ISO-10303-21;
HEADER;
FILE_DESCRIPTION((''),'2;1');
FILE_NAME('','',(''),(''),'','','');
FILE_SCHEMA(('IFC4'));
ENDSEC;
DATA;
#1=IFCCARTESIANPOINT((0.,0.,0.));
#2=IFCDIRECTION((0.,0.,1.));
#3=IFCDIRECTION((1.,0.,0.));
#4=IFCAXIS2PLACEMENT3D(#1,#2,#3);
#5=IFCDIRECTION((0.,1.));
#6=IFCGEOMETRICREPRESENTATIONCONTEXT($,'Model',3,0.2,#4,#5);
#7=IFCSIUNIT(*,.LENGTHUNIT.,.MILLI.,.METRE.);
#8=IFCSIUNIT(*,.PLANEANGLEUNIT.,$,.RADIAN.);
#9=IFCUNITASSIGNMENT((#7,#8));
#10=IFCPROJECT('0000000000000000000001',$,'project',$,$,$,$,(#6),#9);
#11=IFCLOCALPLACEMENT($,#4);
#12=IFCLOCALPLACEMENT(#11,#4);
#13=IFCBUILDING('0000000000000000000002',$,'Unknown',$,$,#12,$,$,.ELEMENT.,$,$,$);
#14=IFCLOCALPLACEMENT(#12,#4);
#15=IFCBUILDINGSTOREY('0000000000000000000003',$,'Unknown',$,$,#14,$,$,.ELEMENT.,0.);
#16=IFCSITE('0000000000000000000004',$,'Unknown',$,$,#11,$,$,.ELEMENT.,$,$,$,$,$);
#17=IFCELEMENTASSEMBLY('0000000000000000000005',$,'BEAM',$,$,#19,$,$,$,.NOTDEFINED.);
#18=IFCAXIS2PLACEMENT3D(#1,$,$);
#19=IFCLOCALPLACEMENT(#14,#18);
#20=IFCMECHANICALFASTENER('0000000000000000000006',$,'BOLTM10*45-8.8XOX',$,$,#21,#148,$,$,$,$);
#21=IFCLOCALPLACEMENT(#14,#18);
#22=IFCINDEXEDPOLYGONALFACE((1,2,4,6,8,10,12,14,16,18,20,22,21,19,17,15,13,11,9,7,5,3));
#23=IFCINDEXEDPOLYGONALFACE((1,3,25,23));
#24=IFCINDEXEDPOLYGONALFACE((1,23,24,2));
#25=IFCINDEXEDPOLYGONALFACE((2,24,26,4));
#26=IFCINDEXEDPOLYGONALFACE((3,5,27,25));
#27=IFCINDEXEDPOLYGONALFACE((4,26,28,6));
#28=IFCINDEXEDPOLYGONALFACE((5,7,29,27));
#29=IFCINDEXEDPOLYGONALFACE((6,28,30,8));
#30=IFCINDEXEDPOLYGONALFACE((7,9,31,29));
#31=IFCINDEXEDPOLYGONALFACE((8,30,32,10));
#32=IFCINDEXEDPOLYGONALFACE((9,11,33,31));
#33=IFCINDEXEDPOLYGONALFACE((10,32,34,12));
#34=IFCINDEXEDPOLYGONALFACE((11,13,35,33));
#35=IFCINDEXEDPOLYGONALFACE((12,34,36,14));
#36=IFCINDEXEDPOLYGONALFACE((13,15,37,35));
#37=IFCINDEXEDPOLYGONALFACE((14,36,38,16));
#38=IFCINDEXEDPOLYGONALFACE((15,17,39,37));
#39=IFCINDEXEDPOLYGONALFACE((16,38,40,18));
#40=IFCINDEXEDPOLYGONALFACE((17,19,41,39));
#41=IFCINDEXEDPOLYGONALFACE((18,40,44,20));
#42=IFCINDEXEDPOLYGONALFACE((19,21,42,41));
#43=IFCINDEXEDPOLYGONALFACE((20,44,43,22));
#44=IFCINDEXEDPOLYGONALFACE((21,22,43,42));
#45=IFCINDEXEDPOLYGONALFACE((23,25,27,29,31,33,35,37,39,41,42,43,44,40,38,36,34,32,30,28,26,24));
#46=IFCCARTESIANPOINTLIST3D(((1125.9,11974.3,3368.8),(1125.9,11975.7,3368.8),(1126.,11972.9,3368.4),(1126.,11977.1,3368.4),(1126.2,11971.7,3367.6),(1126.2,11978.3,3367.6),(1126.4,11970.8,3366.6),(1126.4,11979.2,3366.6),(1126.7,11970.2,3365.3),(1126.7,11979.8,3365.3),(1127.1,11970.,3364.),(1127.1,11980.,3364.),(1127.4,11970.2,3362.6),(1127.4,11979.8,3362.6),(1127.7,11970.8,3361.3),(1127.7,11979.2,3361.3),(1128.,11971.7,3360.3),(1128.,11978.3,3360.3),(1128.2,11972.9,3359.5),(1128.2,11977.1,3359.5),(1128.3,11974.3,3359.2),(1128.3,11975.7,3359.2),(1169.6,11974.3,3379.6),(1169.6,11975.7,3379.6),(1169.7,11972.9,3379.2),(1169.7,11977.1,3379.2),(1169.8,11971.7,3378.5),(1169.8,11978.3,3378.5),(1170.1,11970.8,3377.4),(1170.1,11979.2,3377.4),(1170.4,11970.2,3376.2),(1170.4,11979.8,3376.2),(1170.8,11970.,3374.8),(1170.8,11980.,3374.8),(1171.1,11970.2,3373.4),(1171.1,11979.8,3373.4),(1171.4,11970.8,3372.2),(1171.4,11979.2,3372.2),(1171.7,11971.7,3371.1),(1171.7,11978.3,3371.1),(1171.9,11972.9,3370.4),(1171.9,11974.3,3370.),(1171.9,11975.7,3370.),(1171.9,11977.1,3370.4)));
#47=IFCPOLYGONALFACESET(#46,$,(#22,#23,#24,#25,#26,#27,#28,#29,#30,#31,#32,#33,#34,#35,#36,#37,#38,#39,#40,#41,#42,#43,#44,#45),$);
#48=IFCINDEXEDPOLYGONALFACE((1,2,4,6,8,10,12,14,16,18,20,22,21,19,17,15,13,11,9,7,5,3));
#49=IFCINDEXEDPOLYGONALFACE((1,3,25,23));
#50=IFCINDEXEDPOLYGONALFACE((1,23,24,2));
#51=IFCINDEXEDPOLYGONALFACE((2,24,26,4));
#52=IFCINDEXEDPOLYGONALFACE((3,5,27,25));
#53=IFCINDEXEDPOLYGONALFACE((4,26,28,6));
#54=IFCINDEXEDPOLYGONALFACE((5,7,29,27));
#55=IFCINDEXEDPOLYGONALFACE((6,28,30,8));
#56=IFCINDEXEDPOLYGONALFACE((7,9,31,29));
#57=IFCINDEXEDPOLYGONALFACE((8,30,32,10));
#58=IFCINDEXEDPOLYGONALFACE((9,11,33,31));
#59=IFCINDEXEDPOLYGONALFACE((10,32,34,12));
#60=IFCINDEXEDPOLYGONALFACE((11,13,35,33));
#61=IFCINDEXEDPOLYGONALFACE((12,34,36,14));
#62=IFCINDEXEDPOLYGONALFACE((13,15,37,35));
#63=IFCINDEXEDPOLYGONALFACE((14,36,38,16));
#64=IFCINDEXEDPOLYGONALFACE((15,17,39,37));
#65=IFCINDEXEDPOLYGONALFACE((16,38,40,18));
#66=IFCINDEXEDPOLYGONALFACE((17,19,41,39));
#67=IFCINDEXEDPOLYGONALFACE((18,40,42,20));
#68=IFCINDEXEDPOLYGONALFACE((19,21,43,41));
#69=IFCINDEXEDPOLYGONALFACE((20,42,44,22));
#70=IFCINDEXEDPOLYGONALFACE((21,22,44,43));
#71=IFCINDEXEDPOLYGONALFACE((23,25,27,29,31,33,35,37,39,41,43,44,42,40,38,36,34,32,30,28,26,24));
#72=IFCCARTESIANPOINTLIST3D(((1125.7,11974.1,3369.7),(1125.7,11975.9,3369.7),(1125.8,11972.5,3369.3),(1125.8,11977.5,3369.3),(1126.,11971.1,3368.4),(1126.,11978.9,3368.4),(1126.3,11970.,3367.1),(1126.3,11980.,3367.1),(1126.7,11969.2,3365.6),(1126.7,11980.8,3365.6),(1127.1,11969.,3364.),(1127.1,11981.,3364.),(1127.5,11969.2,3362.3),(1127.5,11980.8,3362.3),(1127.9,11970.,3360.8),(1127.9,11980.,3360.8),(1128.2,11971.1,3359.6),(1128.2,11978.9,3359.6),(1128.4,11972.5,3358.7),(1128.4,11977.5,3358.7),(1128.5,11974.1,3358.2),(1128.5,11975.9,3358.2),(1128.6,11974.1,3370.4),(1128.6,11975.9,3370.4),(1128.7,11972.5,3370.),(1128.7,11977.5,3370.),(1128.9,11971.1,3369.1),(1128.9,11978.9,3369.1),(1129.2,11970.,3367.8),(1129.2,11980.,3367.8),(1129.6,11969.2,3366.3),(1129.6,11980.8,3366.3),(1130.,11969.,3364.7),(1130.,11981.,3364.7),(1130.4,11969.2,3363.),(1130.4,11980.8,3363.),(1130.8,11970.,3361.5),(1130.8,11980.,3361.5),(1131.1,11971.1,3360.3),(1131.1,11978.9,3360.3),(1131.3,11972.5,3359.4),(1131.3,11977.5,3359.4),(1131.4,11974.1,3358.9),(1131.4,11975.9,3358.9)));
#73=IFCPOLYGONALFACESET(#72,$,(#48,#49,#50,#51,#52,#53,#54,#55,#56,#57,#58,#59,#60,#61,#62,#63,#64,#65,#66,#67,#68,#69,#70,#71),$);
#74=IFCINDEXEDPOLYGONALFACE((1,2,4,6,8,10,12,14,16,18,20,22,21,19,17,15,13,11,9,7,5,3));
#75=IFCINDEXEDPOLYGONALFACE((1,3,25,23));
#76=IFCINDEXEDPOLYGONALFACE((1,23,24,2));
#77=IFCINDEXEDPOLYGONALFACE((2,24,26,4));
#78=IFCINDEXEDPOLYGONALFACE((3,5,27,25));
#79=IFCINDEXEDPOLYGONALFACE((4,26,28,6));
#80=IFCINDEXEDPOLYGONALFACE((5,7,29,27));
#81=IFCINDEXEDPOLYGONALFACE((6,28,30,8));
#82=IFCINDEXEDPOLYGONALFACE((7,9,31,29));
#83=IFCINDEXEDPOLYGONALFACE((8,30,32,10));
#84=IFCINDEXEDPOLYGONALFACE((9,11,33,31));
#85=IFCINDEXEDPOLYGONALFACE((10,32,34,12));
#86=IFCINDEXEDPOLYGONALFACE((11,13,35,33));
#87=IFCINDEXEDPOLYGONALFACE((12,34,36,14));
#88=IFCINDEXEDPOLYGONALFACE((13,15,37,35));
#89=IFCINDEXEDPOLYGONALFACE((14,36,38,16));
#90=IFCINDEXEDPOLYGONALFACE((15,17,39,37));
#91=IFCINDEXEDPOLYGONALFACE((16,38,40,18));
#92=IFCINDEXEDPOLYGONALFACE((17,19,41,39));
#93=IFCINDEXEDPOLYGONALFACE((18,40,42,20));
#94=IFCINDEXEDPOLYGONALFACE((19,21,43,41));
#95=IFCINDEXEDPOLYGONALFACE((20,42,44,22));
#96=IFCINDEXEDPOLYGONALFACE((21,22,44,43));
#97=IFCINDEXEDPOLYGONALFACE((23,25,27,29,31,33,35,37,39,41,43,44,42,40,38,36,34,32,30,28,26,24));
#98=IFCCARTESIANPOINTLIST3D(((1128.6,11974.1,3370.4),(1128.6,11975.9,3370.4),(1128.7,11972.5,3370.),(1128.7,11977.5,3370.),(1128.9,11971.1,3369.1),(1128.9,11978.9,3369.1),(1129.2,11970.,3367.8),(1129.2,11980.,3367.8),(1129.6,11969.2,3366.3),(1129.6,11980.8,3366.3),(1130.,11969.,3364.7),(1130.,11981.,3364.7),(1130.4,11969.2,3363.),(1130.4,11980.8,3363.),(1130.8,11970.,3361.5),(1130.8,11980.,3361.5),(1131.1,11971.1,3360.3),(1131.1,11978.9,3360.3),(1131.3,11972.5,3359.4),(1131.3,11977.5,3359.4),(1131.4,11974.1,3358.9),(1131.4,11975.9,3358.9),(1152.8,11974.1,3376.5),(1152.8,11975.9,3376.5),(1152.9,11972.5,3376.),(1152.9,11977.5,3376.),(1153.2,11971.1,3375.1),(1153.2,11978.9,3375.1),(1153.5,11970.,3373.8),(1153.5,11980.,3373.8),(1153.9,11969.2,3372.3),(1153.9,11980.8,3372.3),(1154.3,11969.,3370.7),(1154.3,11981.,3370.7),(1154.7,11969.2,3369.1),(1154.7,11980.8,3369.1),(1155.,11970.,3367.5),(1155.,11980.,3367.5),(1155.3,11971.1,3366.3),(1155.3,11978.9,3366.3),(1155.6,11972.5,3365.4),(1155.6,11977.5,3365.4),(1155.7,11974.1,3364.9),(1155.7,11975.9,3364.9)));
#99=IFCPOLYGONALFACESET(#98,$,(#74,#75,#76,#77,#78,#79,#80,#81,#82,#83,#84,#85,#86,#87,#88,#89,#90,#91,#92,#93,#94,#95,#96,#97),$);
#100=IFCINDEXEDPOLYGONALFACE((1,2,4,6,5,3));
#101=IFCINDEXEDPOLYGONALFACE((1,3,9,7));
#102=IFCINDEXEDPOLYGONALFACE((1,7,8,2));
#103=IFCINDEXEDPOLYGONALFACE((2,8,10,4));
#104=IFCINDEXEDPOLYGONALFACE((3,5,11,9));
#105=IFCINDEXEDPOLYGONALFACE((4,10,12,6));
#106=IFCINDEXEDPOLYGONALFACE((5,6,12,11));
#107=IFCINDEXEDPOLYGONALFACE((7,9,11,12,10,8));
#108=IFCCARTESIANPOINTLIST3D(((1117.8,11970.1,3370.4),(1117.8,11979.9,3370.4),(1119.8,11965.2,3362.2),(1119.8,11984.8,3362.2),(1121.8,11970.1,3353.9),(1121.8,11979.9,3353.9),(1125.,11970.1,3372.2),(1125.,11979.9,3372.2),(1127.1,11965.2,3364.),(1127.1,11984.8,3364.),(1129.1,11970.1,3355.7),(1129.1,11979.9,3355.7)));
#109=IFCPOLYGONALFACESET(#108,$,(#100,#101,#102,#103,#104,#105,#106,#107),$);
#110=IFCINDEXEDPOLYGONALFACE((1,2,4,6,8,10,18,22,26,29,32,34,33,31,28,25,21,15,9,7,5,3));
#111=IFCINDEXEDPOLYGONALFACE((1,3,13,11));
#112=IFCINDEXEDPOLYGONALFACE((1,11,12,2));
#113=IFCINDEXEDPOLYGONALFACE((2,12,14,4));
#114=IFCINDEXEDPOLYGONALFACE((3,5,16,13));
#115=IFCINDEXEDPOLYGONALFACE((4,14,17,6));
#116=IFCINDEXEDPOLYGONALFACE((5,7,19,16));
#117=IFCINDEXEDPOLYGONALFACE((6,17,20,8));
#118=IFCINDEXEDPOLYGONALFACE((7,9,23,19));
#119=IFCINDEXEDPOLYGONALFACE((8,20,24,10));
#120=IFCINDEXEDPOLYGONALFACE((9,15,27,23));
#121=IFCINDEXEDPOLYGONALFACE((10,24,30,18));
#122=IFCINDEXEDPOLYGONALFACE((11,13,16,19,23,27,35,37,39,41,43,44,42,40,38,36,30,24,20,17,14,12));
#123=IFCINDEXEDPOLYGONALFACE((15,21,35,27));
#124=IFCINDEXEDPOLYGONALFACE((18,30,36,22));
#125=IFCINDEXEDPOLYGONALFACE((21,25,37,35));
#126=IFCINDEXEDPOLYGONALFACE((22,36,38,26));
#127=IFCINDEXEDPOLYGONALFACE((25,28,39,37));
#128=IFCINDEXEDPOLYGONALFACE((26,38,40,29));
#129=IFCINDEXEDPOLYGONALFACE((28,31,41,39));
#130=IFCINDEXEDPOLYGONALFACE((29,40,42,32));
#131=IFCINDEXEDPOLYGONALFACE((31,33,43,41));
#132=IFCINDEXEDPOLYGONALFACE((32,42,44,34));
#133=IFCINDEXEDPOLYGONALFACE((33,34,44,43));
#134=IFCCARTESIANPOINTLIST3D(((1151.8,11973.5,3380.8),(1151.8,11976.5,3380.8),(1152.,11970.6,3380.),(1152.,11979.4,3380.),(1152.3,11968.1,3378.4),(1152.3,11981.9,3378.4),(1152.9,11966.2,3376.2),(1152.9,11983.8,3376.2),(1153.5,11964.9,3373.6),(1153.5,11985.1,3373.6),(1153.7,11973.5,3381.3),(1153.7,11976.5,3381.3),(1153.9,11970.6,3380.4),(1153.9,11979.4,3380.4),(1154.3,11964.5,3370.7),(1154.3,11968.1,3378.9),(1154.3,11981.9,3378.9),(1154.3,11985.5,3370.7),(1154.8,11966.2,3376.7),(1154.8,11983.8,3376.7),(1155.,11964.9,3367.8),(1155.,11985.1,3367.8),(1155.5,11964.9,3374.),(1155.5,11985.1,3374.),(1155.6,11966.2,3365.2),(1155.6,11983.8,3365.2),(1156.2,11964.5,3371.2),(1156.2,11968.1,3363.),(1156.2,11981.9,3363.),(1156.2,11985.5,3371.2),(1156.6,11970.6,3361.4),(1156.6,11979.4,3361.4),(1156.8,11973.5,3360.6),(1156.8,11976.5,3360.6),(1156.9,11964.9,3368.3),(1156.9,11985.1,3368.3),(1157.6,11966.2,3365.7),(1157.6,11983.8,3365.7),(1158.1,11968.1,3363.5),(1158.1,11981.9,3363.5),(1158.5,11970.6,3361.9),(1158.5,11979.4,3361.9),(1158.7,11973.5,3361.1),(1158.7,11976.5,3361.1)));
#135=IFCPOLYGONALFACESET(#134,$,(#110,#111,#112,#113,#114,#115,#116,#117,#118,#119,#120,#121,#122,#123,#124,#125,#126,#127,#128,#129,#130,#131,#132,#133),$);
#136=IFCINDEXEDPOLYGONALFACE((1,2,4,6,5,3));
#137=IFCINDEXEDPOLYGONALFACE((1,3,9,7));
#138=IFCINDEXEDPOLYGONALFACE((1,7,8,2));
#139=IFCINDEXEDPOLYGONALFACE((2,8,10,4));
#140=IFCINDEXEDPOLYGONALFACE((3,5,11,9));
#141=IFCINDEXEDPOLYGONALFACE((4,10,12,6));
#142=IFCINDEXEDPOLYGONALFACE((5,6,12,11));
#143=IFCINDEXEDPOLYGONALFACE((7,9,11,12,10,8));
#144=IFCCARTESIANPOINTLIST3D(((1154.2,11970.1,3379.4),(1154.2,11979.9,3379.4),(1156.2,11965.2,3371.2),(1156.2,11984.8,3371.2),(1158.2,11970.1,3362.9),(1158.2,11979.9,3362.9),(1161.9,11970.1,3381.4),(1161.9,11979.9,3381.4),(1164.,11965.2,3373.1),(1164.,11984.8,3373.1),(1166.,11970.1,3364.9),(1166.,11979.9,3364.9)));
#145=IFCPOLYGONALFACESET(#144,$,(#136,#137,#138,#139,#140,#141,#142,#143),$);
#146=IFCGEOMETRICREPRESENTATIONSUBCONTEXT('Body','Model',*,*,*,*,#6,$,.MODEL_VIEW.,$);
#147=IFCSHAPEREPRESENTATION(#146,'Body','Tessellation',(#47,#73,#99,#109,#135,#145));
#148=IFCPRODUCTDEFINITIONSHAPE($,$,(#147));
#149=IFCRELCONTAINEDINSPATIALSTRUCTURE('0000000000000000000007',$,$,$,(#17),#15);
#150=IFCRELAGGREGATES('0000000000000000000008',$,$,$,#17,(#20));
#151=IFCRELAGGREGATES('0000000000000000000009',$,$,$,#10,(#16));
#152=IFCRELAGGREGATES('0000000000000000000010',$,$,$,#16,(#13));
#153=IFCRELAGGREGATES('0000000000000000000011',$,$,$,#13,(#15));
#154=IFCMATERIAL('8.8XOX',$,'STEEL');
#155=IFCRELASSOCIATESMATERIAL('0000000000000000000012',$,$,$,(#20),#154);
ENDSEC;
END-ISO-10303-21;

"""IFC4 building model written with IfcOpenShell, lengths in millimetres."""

from ifc_helpers import new_model, si_unit, direction, frame, origin_with_axes, place, context, subcontext, project, spatial, line, arc, indexed_curve, outline, extrude, source, transform, mapped, material, element, aggregate, save


model = new_model("IFC4")

# Units and contexts
model_context = context("Model", 3, precision=0.2, world=origin_with_axes(), true_north=direction((0.0, 1.0)))
body_context = subcontext(model_context, "Body", "Model", "MODEL_VIEW")
ifc_project = project(units=[si_unit("LENGTHUNIT", "METRE", prefix="MILLI"), si_unit("PLANEANGLEUNIT", "RADIAN")], contexts=[model_context])

# Site, building, storey
site_placement = place(None, origin_with_axes())
site = spatial("IfcSite", under=ifc_project, at=site_placement, Name="Unknown", CompositionType="ELEMENT")
building_placement = place(site_placement, origin_with_axes())
building = spatial("IfcBuilding", under=site, at=building_placement, Name="Unknown", CompositionType="ELEMENT")
storey_placement = place(building_placement, origin_with_axes())
storey = spatial("IfcBuildingStorey", under=building, at=storey_placement, Name="Unknown", CompositionType="ELEMENT", Elevation=0.0)

# Shared definitions
ifc_material_1 = material(Name="8.8XOX", Category="STEEL")

# Element assembly, mechanical fastener
shared_shape_1 = source(origin_with_axes(), body_context, "Body", "SweptSolid", [
    extrude(outline(indexed_curve([(5.0, 0.0), (0.0, 5.0), (-5.0, 0.0), (0.0, -5.0)], segments=[arc(1, 2, 3), arc(3, 4, 1)])), frame((0.0, 0.0, 3.8), z_axis=(0.0, 0.0, -1.0), x_axis=(0.0, 1.0, 0.0)), (0.0, 0.0, 1.0), 45.0),
    extrude(outline(indexed_curve([(6.0, 0.0), (0.0, 6.0), (-6.0, 0.0), (0.0, -6.0)], segments=[arc(1, 2, 3), arc(3, 4, 1)])), frame((0.0, 0.0, 3.8), z_axis=(0.0, 0.0, -1.0), x_axis=(0.0, 1.0, 0.0)), (0.0, 0.0, 1.0), 3.0),
    extrude(outline(indexed_curve([(6.0, 0.0), (0.0, 6.0), (-6.0, 0.0), (0.0, -6.0)], segments=[arc(1, 2, 3), arc(3, 4, 1)])), frame((0.0, 0.0, 0.8), z_axis=(0.0, 0.0, -1.0), x_axis=(0.0, 1.0, 0.0)), (0.0, 0.0, 1.0), 25.0),
    extrude(outline(indexed_curve([(9.8, 0.0), (4.9, 8.5), (-4.9, 8.5), (-9.8, 0.0), (-4.9, -8.5), (4.9, -8.5)], segments=[line(1, 2, 3, 4, 5, 6, 1)])), frame((0.0, 0.0, 11.2), z_axis=(0.0, 0.0, -1.0), x_axis=(0.0, 1.0, 0.0)), (0.0, 0.0, 1.0), 7.5),
    extrude(outline(indexed_curve([(10.5, 0.0), (0.0, 10.5), (-10.5, 0.0), (0.0, -10.5)], segments=[arc(1, 2, 3), arc(3, 4, 1)])), frame((0.0, 0.0, -24.2), z_axis=(0.0, 0.0, -1.0), x_axis=(0.0, 1.0, 0.0)), (0.0, 0.0, 1.0), 2.0),
    extrude(outline(indexed_curve([(9.8, 0.0), (4.9, 8.5), (-4.9, 8.5), (-9.8, 0.0), (-4.9, -8.5), (4.9, -8.5)], segments=[line(1, 2, 3, 4, 5, 6, 1)])), frame((0.0, 0.0, -26.2), z_axis=(0.0, 0.0, -1.0), x_axis=(0.0, 1.0, 0.0)), (0.0, 0.0, 1.0), 8.0),
])
assembly_1_placement = place(storey_placement, frame((1140.9, 6000.0, 3372.5), z_axis=(0.970613, 0.0, 0.240648), x_axis=(0.0, 1.0, 0.0)))
assembly_1 = element("IfcElementAssembly", 1, at=assembly_1_placement, inside=storey, Name="BEAM", PredefinedType="NOTDEFINED")
mechanical_fastener_1_placement = place(assembly_1_placement, frame((5975.0, -5.0, -11.8), z_axis=(0.0, 0.0, -1.0), x_axis=(0.0, 1.0, 0.0)))
mechanical_fastener_1 = element("IfcMechanicalFastener", 2, at=mechanical_fastener_1_placement, material=ifc_material_1, Name="BOLTM10*45-8.8XOX", context=body_context, shape_type="MappedRepresentation", body=[
    mapped(shared_shape_1, transform((0.0, 0.0, 0.0))),
])
aggregate(assembly_1, [mechanical_fastener_1])

save(model, "model.ifc")
